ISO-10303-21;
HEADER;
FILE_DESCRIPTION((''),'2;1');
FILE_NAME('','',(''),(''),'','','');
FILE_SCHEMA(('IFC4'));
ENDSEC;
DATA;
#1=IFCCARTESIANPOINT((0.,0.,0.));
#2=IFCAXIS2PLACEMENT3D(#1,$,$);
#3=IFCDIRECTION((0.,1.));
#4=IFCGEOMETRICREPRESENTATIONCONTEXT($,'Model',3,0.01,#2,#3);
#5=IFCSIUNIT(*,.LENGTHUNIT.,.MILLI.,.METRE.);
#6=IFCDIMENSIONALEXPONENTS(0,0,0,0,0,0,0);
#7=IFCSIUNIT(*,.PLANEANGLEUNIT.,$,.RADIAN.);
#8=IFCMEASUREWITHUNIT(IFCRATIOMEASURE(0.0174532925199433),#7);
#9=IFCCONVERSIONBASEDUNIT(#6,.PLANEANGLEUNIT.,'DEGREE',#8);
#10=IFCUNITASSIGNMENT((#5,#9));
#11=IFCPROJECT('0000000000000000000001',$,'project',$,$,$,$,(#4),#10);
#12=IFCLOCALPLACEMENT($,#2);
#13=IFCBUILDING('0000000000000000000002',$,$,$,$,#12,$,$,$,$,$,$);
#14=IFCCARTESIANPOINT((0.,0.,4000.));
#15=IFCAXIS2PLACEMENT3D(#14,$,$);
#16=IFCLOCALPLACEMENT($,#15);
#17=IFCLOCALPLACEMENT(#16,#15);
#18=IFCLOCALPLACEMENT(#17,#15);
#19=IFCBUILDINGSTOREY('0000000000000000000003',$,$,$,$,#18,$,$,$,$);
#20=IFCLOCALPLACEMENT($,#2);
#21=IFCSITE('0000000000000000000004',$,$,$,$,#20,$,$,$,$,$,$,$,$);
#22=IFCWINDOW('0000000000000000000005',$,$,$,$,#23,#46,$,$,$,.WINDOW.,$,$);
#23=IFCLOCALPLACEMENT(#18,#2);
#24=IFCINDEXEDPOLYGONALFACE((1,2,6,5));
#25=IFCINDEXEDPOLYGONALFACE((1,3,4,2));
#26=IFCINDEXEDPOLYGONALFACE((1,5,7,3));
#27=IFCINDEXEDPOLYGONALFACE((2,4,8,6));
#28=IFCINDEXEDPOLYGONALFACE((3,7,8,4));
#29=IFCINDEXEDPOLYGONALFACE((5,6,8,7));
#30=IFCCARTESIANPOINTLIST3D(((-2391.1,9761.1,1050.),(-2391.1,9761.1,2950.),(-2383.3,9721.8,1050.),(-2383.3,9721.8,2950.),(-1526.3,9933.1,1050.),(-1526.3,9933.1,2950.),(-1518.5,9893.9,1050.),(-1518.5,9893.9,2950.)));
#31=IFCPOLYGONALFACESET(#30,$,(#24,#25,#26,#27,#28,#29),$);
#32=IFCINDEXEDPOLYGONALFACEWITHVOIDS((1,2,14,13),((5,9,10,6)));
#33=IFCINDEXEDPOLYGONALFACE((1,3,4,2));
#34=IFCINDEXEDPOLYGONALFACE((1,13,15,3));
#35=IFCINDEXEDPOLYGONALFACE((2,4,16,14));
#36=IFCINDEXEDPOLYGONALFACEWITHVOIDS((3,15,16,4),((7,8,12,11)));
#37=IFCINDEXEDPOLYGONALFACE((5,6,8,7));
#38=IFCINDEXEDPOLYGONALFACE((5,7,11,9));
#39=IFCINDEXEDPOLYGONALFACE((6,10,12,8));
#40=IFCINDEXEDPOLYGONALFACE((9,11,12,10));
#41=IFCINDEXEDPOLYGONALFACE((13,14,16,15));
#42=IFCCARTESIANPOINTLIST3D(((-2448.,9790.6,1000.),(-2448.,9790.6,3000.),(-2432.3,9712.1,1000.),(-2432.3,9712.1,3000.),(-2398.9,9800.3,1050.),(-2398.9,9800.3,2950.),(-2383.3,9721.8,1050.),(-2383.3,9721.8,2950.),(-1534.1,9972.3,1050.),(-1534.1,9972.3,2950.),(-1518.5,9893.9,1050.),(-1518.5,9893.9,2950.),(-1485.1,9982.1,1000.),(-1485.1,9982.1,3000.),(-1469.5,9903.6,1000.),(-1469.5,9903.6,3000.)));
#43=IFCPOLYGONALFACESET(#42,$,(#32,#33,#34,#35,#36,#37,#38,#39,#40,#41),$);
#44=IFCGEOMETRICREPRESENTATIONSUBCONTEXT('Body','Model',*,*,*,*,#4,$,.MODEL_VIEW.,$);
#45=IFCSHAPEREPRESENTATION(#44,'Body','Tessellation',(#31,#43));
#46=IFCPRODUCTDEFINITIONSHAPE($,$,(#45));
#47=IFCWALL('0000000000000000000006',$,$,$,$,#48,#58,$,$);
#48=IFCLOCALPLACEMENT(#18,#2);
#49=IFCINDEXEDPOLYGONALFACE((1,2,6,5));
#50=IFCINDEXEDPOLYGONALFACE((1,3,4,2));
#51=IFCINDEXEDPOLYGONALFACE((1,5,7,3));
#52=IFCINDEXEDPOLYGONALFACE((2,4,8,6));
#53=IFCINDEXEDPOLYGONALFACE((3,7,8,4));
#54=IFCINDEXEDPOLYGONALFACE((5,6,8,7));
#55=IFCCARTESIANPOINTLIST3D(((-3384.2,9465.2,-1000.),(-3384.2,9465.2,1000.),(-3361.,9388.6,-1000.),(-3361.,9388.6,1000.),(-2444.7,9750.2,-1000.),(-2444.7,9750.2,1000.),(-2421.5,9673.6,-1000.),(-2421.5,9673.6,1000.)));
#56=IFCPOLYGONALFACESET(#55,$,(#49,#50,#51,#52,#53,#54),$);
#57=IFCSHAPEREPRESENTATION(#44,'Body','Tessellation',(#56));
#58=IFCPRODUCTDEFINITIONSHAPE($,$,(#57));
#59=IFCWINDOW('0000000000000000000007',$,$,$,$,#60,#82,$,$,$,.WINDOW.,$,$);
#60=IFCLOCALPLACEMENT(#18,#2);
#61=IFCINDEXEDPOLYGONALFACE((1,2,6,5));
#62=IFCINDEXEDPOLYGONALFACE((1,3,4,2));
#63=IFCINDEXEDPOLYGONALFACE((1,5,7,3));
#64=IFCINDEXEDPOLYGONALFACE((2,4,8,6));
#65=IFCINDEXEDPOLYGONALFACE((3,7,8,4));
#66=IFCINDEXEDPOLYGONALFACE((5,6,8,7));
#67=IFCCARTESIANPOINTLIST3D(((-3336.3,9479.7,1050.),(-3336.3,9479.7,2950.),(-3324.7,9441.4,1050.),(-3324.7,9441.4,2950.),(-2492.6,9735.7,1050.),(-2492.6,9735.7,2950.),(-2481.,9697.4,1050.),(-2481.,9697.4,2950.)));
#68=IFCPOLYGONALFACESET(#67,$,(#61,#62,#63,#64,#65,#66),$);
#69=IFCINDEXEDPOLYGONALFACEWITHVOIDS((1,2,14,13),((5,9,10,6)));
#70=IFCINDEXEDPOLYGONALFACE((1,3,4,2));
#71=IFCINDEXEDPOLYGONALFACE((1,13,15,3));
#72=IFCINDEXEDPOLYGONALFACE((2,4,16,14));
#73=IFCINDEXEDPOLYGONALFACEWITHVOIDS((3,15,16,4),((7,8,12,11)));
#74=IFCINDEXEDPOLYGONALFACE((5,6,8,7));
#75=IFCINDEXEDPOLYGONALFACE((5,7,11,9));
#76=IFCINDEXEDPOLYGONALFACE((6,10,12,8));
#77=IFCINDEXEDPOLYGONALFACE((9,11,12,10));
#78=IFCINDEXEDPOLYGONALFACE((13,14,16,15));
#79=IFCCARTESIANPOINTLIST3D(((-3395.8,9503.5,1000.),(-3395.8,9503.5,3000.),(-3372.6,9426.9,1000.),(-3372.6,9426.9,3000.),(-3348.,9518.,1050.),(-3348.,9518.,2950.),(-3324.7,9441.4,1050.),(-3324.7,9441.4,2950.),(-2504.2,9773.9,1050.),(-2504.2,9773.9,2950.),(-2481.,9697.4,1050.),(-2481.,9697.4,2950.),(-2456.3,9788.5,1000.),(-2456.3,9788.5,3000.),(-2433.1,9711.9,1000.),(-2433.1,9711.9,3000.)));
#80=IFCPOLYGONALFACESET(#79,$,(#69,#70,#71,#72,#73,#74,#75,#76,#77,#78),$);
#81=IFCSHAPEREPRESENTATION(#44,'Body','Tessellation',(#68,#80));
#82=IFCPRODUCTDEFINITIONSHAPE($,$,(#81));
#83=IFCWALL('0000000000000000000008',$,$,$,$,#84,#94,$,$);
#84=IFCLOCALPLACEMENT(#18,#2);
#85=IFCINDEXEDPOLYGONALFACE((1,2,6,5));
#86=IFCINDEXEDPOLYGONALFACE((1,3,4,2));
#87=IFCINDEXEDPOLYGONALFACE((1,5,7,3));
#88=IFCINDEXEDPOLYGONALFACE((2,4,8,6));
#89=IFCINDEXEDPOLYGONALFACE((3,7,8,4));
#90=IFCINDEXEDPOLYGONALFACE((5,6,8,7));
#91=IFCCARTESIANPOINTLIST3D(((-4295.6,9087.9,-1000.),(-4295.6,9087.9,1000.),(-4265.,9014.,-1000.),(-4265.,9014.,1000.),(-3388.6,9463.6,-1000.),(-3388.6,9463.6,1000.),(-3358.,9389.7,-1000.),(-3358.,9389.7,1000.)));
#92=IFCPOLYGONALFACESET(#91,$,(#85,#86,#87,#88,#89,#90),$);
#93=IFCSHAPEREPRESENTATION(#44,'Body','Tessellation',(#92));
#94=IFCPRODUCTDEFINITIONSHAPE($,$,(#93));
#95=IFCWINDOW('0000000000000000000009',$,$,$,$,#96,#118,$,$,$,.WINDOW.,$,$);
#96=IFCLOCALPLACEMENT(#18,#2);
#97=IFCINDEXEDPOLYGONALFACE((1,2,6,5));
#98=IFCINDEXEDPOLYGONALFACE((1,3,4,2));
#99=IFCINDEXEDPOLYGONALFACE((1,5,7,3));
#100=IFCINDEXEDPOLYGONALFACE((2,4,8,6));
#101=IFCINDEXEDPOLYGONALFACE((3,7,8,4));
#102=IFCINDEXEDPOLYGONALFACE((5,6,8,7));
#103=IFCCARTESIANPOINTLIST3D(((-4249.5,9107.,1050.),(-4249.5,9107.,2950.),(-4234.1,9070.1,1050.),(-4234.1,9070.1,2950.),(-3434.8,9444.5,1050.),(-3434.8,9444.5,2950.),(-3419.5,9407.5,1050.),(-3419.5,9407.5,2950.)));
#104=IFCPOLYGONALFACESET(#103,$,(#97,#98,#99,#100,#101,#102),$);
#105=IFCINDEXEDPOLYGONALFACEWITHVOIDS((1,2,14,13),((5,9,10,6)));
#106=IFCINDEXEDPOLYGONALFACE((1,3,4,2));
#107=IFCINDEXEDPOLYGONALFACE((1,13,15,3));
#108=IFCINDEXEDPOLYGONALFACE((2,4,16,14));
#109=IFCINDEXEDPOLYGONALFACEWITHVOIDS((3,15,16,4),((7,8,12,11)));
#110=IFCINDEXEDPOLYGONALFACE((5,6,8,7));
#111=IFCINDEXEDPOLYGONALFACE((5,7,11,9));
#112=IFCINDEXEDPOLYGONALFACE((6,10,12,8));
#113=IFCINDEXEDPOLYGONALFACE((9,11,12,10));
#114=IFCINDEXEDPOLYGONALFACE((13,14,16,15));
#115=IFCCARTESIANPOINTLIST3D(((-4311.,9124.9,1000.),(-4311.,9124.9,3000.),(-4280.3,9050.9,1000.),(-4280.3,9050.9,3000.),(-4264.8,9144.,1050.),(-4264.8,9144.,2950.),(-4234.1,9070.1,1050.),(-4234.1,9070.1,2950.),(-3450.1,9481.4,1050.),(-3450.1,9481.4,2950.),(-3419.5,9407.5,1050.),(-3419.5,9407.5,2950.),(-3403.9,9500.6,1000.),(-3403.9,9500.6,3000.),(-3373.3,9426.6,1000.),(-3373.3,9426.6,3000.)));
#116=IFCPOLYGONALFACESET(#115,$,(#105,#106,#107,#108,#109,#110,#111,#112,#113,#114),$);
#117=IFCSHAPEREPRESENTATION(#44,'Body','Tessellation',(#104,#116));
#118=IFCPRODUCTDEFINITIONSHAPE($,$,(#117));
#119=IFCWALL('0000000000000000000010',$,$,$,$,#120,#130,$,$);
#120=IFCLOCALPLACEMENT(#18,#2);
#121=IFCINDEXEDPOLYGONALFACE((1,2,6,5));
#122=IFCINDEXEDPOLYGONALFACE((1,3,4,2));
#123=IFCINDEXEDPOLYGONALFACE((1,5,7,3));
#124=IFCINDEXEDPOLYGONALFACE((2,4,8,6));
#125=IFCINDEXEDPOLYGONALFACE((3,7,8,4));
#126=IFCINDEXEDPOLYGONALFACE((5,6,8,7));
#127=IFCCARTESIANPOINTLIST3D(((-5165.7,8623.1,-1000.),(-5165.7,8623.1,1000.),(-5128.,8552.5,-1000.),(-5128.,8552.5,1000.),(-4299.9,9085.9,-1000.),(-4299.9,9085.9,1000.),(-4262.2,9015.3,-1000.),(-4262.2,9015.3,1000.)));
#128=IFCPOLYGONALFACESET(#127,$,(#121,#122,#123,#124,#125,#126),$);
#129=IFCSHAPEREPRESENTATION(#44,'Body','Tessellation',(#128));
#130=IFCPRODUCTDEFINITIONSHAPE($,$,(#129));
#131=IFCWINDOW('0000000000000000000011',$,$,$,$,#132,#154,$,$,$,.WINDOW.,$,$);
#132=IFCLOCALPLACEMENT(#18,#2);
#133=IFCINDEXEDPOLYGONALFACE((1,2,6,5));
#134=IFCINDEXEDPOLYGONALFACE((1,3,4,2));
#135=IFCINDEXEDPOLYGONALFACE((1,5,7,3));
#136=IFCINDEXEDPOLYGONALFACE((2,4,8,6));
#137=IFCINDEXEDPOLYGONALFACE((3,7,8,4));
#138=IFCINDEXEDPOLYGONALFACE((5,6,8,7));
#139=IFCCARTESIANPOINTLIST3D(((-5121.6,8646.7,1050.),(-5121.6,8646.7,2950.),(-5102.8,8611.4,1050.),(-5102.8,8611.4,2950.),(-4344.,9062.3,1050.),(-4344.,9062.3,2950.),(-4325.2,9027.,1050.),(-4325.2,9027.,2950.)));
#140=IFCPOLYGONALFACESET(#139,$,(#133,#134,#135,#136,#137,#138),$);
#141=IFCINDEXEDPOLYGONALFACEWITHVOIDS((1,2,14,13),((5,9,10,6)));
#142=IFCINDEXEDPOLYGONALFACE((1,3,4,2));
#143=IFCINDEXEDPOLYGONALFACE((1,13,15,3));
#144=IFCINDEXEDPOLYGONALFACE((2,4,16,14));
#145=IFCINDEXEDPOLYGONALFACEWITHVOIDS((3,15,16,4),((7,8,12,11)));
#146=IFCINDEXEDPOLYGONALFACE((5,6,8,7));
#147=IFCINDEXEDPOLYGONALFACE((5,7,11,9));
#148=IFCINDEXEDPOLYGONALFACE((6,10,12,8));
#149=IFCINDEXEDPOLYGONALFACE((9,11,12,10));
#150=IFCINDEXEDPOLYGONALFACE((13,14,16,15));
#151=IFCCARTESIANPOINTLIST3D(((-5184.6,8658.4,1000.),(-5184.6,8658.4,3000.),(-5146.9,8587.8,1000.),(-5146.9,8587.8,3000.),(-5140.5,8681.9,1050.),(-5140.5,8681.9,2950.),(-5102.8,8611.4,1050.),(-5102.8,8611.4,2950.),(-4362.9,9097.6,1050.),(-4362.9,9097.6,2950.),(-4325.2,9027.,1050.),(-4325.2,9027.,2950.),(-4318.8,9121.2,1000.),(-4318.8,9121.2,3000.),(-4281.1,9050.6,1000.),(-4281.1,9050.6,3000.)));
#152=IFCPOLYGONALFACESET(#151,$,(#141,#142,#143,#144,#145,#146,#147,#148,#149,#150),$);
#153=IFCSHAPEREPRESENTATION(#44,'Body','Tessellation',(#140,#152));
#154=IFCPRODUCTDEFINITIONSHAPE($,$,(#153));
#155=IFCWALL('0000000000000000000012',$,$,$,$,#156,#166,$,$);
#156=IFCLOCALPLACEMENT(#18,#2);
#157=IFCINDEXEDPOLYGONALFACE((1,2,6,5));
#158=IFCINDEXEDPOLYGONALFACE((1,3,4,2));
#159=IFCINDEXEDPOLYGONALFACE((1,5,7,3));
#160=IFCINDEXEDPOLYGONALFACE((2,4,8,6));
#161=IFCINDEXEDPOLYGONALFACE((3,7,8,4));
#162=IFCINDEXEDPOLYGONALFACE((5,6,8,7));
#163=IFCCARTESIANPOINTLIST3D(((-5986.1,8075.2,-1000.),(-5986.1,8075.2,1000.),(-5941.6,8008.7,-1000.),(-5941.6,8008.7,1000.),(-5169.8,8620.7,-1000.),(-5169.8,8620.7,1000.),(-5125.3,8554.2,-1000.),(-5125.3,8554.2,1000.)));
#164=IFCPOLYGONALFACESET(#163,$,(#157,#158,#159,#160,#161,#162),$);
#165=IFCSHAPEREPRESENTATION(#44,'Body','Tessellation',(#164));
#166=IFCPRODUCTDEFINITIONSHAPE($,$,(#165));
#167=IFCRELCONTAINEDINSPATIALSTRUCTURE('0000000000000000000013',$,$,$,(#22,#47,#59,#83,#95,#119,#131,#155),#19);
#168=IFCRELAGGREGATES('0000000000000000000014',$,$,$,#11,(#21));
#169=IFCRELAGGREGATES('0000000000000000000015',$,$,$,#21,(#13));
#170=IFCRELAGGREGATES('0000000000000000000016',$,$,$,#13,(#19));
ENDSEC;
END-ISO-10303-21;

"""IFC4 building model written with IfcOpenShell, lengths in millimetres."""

from ifc_helpers import new_model, entity, si_unit, converted_unit, direction, frame, origin, origin_2d, place, context, subcontext, project, spatial, rectangle, extrude, element, save


model = new_model("IFC4")

# Units and contexts
model_context = context("Model", 3, precision=0.01, world=origin(), true_north=direction((0.0, 1.0)))
body_context = subcontext(model_context, "Body", "Model", "MODEL_VIEW")
ifc_project = project(units=[si_unit("LENGTHUNIT", "METRE", prefix="MILLI"), converted_unit("PLANEANGLEUNIT", "DEGREE", entity("IfcRatioMeasure", 0.0174532925199433), si_unit("PLANEANGLEUNIT", "RADIAN"), dimensions=[0, 0, 0, 0, 0, 0, 0])], contexts=[model_context])

# Site, building, storey
site_placement = place(None, origin())
site = spatial("IfcSite", under=ifc_project, at=site_placement)
building_placement = place(None, origin())
building = spatial("IfcBuilding", under=site, at=building_placement)
placement_1 = place(None, frame((0.0, 0.0, 4000.0)))
placement_2 = place(placement_1, frame((0.0, 0.0, 4000.0)))
storey_placement = place(placement_2, frame((0.0, 0.0, 4000.0)))
storey = spatial("IfcBuildingStorey", under=building, at=storey_placement)

# Shared definitions
cartesian_point_1 = entity("IfcCartesianPoint", [-440.9, -950.0])
shared_polyline = entity("IfcPolyline", [cartesian_point_1, entity("IfcCartesianPoint", [-440.9, 950.0]), entity("IfcCartesianPoint", [-440.9, 950.0]), entity("IfcCartesianPoint", [440.9, 950.0]), entity("IfcCartesianPoint", [440.9, 950.0]), entity("IfcCartesianPoint", [440.9, -950.0]), entity("IfcCartesianPoint", [440.9, -950.0]), entity("IfcCartesianPoint", [-440.9, -950.0]), cartesian_point_1])

# Window
window_1_placement = place(storey_placement, frame((-1950.9, 9807.9, 2000.0), z_axis=(0.0, 0.0, 1.0), x_axis=(-9807.852795, -1950.903264, 0.0)))
cartesian_point_2 = entity("IfcCartesianPoint", [-490.9, -1000.0])
element("IfcWindow", 1, at=window_1_placement, inside=storey, PredefinedType="WINDOW", context=body_context, shape_type="SweptSolid", body=[
    entity("IfcExtrudedAreaSolid", entity("IfcArbitraryClosedProfileDef", "AREA", None, shared_polyline), entity("IfcAxis2Placement3D", entity("IfcCartesianPoint", [0.0, 0.0, 0.0]), entity("IfcDirection", [0.0, -1.0, 0.0]), entity("IfcDirection", [1.0, 0.0, 0.0])), entity("IfcDirection", [0.0, 0.0, 1.0]), 40.0),
    entity("IfcExtrudedAreaSolid", entity("IfcArbitraryProfileDefWithVoids", "AREA", None, entity("IfcPolyline", [cartesian_point_2, entity("IfcCartesianPoint", [-490.9, 1000.0]), entity("IfcCartesianPoint", [-490.9, 1000.0]), entity("IfcCartesianPoint", [490.9, 1000.0]), entity("IfcCartesianPoint", [490.9, 1000.0]), entity("IfcCartesianPoint", [490.9, -1000.0]), entity("IfcCartesianPoint", [490.9, -1000.0]), entity("IfcCartesianPoint", [-490.9, -1000.0]), cartesian_point_2]), [shared_polyline]), entity("IfcAxis2Placement3D", entity("IfcCartesianPoint", [0.0, 0.0, 0.0]), entity("IfcDirection", [0.0, -1.0, 0.0]), entity("IfcDirection", [1.0, 0.0, 0.0])), entity("IfcDirection", [0.0, 0.0, 1.0]), 80.0),
])

# Wall
wall_1_placement = place(storey_placement, frame((-2902.8, 9569.4, -1000.0), z_axis=(0.0, 0.0, 1.0), x_axis=(-9569.403228, -2902.847198, 0.0)))
element("IfcWall", 2, at=wall_1_placement, inside=storey, context=body_context, shape_type="SweptSolid", body=[
    extrude(rectangle(XDim=981.7, YDim=80.0, at=origin_2d()), origin(), (0.0, 0.0, 1.0), 2000.0),
])

# Window
window_2_placement = place(storey_placement, frame((-2902.8, 9569.4, 2000.0), z_axis=(0.0, 0.0, 1.0), x_axis=(-9569.403228, -2902.847198, 0.0)))
cartesian_point_3 = entity("IfcCartesianPoint", [-490.9, -1000.0])
element("IfcWindow", 3, at=window_2_placement, inside=storey, PredefinedType="WINDOW", context=body_context, shape_type="SweptSolid", body=[
    entity("IfcExtrudedAreaSolid", entity("IfcArbitraryClosedProfileDef", "AREA", None, shared_polyline), entity("IfcAxis2Placement3D", entity("IfcCartesianPoint", [0.0, 0.0, 0.0]), entity("IfcDirection", [0.0, -1.0, 0.0]), entity("IfcDirection", [1.0, 0.0, 0.0])), entity("IfcDirection", [0.0, 0.0, 1.0]), 40.0),
    entity("IfcExtrudedAreaSolid", entity("IfcArbitraryProfileDefWithVoids", "AREA", None, entity("IfcPolyline", [cartesian_point_3, entity("IfcCartesianPoint", [-490.9, 1000.0]), entity("IfcCartesianPoint", [-490.9, 1000.0]), entity("IfcCartesianPoint", [490.9, 1000.0]), entity("IfcCartesianPoint", [490.9, 1000.0]), entity("IfcCartesianPoint", [490.9, -1000.0]), entity("IfcCartesianPoint", [490.9, -1000.0]), entity("IfcCartesianPoint", [-490.9, -1000.0]), cartesian_point_3]), [shared_polyline]), entity("IfcAxis2Placement3D", entity("IfcCartesianPoint", [0.0, 0.0, 0.0]), entity("IfcDirection", [0.0, -1.0, 0.0]), entity("IfcDirection", [1.0, 0.0, 0.0])), entity("IfcDirection", [0.0, 0.0, 1.0]), 80.0),
])

# Wall
wall_2_placement = place(storey_placement, frame((-3826.8, 9238.8, -1000.0), z_axis=(0.0, 0.0, 1.0), x_axis=(-9238.795458, -3826.834002, 0.0)))
element("IfcWall", 4, at=wall_2_placement, inside=storey, context=body_context, shape_type="SweptSolid", body=[
    extrude(rectangle(XDim=981.7, YDim=80.0, at=origin_2d()), origin(), (0.0, 0.0, 1.0), 2000.0),
])

# Window
window_3_placement = place(storey_placement, frame((-3826.8, 9238.8, 2000.0), z_axis=(0.0, 0.0, 1.0), x_axis=(-9238.795458, -3826.834002, 0.0)))
cartesian_point_4 = entity("IfcCartesianPoint", [-490.9, -1000.0])
element("IfcWindow", 5, at=window_3_placement, inside=storey, PredefinedType="WINDOW", context=body_context, shape_type="SweptSolid", body=[
    entity("IfcExtrudedAreaSolid", entity("IfcArbitraryClosedProfileDef", "AREA", None, shared_polyline), entity("IfcAxis2Placement3D", entity("IfcCartesianPoint", [0.0, 0.0, 0.0]), entity("IfcDirection", [0.0, -1.0, 0.0]), entity("IfcDirection", [1.0, 0.0, 0.0])), entity("IfcDirection", [0.0, 0.0, 1.0]), 40.0),
    entity("IfcExtrudedAreaSolid", entity("IfcArbitraryProfileDefWithVoids", "AREA", None, entity("IfcPolyline", [cartesian_point_4, entity("IfcCartesianPoint", [-490.9, 1000.0]), entity("IfcCartesianPoint", [-490.9, 1000.0]), entity("IfcCartesianPoint", [490.9, 1000.0]), entity("IfcCartesianPoint", [490.9, 1000.0]), entity("IfcCartesianPoint", [490.9, -1000.0]), entity("IfcCartesianPoint", [490.9, -1000.0]), entity("IfcCartesianPoint", [-490.9, -1000.0]), cartesian_point_4]), [shared_polyline]), entity("IfcAxis2Placement3D", entity("IfcCartesianPoint", [0.0, 0.0, 0.0]), entity("IfcDirection", [0.0, -1.0, 0.0]), entity("IfcDirection", [1.0, 0.0, 0.0])), entity("IfcDirection", [0.0, 0.0, 1.0]), 80.0),
])

# Wall
wall_3_placement = place(storey_placement, frame((-4714.0, 8819.2, -1000.0), z_axis=(0.0, 0.0, 1.0), x_axis=(-8819.213181, -4713.966363, 0.0)))
element("IfcWall", 6, at=wall_3_placement, inside=storey, context=body_context, shape_type="SweptSolid", body=[
    extrude(rectangle(XDim=981.7, YDim=80.0, at=origin_2d()), origin(), (0.0, 0.0, 1.0), 2000.0),
])

# Window
window_4_placement = place(storey_placement, frame((-4714.0, 8819.2, 2000.0), z_axis=(0.0, 0.0, 1.0), x_axis=(-8819.213181, -4713.966363, 0.0)))
cartesian_point_5 = entity("IfcCartesianPoint", [-490.9, -1000.0])
element("IfcWindow", 7, at=window_4_placement, inside=storey, PredefinedType="WINDOW", context=body_context, shape_type="SweptSolid", body=[
    entity("IfcExtrudedAreaSolid", entity("IfcArbitraryClosedProfileDef", "AREA", None, shared_polyline), entity("IfcAxis2Placement3D", entity("IfcCartesianPoint", [0.0, 0.0, 0.0]), entity("IfcDirection", [0.0, -1.0, 0.0]), entity("IfcDirection", [1.0, 0.0, 0.0])), entity("IfcDirection", [0.0, 0.0, 1.0]), 40.0),
    entity("IfcExtrudedAreaSolid", entity("IfcArbitraryProfileDefWithVoids", "AREA", None, entity("IfcPolyline", [cartesian_point_5, entity("IfcCartesianPoint", [-490.9, 1000.0]), entity("IfcCartesianPoint", [-490.9, 1000.0]), entity("IfcCartesianPoint", [490.9, 1000.0]), entity("IfcCartesianPoint", [490.9, 1000.0]), entity("IfcCartesianPoint", [490.9, -1000.0]), entity("IfcCartesianPoint", [490.9, -1000.0]), entity("IfcCartesianPoint", [-490.9, -1000.0]), cartesian_point_5]), [shared_polyline]), entity("IfcAxis2Placement3D", entity("IfcCartesianPoint", [0.0, 0.0, 0.0]), entity("IfcDirection", [0.0, -1.0, 0.0]), entity("IfcDirection", [1.0, 0.0, 0.0])), entity("IfcDirection", [0.0, 0.0, 1.0]), 80.0),
])

# Wall
wall_4_placement = place(storey_placement, frame((-5555.7, 8314.7, -1000.0), z_axis=(0.0, 0.0, 1.0), x_axis=(-8314.696534, -5555.701715, 0.0)))
element("IfcWall", 8, at=wall_4_placement, inside=storey, context=body_context, shape_type="SweptSolid", body=[
    extrude(rectangle(XDim=981.7, YDim=80.0, at=origin_2d()), origin(), (0.0, 0.0, 1.0), 2000.0),
])

save(model, "model.ifc")
